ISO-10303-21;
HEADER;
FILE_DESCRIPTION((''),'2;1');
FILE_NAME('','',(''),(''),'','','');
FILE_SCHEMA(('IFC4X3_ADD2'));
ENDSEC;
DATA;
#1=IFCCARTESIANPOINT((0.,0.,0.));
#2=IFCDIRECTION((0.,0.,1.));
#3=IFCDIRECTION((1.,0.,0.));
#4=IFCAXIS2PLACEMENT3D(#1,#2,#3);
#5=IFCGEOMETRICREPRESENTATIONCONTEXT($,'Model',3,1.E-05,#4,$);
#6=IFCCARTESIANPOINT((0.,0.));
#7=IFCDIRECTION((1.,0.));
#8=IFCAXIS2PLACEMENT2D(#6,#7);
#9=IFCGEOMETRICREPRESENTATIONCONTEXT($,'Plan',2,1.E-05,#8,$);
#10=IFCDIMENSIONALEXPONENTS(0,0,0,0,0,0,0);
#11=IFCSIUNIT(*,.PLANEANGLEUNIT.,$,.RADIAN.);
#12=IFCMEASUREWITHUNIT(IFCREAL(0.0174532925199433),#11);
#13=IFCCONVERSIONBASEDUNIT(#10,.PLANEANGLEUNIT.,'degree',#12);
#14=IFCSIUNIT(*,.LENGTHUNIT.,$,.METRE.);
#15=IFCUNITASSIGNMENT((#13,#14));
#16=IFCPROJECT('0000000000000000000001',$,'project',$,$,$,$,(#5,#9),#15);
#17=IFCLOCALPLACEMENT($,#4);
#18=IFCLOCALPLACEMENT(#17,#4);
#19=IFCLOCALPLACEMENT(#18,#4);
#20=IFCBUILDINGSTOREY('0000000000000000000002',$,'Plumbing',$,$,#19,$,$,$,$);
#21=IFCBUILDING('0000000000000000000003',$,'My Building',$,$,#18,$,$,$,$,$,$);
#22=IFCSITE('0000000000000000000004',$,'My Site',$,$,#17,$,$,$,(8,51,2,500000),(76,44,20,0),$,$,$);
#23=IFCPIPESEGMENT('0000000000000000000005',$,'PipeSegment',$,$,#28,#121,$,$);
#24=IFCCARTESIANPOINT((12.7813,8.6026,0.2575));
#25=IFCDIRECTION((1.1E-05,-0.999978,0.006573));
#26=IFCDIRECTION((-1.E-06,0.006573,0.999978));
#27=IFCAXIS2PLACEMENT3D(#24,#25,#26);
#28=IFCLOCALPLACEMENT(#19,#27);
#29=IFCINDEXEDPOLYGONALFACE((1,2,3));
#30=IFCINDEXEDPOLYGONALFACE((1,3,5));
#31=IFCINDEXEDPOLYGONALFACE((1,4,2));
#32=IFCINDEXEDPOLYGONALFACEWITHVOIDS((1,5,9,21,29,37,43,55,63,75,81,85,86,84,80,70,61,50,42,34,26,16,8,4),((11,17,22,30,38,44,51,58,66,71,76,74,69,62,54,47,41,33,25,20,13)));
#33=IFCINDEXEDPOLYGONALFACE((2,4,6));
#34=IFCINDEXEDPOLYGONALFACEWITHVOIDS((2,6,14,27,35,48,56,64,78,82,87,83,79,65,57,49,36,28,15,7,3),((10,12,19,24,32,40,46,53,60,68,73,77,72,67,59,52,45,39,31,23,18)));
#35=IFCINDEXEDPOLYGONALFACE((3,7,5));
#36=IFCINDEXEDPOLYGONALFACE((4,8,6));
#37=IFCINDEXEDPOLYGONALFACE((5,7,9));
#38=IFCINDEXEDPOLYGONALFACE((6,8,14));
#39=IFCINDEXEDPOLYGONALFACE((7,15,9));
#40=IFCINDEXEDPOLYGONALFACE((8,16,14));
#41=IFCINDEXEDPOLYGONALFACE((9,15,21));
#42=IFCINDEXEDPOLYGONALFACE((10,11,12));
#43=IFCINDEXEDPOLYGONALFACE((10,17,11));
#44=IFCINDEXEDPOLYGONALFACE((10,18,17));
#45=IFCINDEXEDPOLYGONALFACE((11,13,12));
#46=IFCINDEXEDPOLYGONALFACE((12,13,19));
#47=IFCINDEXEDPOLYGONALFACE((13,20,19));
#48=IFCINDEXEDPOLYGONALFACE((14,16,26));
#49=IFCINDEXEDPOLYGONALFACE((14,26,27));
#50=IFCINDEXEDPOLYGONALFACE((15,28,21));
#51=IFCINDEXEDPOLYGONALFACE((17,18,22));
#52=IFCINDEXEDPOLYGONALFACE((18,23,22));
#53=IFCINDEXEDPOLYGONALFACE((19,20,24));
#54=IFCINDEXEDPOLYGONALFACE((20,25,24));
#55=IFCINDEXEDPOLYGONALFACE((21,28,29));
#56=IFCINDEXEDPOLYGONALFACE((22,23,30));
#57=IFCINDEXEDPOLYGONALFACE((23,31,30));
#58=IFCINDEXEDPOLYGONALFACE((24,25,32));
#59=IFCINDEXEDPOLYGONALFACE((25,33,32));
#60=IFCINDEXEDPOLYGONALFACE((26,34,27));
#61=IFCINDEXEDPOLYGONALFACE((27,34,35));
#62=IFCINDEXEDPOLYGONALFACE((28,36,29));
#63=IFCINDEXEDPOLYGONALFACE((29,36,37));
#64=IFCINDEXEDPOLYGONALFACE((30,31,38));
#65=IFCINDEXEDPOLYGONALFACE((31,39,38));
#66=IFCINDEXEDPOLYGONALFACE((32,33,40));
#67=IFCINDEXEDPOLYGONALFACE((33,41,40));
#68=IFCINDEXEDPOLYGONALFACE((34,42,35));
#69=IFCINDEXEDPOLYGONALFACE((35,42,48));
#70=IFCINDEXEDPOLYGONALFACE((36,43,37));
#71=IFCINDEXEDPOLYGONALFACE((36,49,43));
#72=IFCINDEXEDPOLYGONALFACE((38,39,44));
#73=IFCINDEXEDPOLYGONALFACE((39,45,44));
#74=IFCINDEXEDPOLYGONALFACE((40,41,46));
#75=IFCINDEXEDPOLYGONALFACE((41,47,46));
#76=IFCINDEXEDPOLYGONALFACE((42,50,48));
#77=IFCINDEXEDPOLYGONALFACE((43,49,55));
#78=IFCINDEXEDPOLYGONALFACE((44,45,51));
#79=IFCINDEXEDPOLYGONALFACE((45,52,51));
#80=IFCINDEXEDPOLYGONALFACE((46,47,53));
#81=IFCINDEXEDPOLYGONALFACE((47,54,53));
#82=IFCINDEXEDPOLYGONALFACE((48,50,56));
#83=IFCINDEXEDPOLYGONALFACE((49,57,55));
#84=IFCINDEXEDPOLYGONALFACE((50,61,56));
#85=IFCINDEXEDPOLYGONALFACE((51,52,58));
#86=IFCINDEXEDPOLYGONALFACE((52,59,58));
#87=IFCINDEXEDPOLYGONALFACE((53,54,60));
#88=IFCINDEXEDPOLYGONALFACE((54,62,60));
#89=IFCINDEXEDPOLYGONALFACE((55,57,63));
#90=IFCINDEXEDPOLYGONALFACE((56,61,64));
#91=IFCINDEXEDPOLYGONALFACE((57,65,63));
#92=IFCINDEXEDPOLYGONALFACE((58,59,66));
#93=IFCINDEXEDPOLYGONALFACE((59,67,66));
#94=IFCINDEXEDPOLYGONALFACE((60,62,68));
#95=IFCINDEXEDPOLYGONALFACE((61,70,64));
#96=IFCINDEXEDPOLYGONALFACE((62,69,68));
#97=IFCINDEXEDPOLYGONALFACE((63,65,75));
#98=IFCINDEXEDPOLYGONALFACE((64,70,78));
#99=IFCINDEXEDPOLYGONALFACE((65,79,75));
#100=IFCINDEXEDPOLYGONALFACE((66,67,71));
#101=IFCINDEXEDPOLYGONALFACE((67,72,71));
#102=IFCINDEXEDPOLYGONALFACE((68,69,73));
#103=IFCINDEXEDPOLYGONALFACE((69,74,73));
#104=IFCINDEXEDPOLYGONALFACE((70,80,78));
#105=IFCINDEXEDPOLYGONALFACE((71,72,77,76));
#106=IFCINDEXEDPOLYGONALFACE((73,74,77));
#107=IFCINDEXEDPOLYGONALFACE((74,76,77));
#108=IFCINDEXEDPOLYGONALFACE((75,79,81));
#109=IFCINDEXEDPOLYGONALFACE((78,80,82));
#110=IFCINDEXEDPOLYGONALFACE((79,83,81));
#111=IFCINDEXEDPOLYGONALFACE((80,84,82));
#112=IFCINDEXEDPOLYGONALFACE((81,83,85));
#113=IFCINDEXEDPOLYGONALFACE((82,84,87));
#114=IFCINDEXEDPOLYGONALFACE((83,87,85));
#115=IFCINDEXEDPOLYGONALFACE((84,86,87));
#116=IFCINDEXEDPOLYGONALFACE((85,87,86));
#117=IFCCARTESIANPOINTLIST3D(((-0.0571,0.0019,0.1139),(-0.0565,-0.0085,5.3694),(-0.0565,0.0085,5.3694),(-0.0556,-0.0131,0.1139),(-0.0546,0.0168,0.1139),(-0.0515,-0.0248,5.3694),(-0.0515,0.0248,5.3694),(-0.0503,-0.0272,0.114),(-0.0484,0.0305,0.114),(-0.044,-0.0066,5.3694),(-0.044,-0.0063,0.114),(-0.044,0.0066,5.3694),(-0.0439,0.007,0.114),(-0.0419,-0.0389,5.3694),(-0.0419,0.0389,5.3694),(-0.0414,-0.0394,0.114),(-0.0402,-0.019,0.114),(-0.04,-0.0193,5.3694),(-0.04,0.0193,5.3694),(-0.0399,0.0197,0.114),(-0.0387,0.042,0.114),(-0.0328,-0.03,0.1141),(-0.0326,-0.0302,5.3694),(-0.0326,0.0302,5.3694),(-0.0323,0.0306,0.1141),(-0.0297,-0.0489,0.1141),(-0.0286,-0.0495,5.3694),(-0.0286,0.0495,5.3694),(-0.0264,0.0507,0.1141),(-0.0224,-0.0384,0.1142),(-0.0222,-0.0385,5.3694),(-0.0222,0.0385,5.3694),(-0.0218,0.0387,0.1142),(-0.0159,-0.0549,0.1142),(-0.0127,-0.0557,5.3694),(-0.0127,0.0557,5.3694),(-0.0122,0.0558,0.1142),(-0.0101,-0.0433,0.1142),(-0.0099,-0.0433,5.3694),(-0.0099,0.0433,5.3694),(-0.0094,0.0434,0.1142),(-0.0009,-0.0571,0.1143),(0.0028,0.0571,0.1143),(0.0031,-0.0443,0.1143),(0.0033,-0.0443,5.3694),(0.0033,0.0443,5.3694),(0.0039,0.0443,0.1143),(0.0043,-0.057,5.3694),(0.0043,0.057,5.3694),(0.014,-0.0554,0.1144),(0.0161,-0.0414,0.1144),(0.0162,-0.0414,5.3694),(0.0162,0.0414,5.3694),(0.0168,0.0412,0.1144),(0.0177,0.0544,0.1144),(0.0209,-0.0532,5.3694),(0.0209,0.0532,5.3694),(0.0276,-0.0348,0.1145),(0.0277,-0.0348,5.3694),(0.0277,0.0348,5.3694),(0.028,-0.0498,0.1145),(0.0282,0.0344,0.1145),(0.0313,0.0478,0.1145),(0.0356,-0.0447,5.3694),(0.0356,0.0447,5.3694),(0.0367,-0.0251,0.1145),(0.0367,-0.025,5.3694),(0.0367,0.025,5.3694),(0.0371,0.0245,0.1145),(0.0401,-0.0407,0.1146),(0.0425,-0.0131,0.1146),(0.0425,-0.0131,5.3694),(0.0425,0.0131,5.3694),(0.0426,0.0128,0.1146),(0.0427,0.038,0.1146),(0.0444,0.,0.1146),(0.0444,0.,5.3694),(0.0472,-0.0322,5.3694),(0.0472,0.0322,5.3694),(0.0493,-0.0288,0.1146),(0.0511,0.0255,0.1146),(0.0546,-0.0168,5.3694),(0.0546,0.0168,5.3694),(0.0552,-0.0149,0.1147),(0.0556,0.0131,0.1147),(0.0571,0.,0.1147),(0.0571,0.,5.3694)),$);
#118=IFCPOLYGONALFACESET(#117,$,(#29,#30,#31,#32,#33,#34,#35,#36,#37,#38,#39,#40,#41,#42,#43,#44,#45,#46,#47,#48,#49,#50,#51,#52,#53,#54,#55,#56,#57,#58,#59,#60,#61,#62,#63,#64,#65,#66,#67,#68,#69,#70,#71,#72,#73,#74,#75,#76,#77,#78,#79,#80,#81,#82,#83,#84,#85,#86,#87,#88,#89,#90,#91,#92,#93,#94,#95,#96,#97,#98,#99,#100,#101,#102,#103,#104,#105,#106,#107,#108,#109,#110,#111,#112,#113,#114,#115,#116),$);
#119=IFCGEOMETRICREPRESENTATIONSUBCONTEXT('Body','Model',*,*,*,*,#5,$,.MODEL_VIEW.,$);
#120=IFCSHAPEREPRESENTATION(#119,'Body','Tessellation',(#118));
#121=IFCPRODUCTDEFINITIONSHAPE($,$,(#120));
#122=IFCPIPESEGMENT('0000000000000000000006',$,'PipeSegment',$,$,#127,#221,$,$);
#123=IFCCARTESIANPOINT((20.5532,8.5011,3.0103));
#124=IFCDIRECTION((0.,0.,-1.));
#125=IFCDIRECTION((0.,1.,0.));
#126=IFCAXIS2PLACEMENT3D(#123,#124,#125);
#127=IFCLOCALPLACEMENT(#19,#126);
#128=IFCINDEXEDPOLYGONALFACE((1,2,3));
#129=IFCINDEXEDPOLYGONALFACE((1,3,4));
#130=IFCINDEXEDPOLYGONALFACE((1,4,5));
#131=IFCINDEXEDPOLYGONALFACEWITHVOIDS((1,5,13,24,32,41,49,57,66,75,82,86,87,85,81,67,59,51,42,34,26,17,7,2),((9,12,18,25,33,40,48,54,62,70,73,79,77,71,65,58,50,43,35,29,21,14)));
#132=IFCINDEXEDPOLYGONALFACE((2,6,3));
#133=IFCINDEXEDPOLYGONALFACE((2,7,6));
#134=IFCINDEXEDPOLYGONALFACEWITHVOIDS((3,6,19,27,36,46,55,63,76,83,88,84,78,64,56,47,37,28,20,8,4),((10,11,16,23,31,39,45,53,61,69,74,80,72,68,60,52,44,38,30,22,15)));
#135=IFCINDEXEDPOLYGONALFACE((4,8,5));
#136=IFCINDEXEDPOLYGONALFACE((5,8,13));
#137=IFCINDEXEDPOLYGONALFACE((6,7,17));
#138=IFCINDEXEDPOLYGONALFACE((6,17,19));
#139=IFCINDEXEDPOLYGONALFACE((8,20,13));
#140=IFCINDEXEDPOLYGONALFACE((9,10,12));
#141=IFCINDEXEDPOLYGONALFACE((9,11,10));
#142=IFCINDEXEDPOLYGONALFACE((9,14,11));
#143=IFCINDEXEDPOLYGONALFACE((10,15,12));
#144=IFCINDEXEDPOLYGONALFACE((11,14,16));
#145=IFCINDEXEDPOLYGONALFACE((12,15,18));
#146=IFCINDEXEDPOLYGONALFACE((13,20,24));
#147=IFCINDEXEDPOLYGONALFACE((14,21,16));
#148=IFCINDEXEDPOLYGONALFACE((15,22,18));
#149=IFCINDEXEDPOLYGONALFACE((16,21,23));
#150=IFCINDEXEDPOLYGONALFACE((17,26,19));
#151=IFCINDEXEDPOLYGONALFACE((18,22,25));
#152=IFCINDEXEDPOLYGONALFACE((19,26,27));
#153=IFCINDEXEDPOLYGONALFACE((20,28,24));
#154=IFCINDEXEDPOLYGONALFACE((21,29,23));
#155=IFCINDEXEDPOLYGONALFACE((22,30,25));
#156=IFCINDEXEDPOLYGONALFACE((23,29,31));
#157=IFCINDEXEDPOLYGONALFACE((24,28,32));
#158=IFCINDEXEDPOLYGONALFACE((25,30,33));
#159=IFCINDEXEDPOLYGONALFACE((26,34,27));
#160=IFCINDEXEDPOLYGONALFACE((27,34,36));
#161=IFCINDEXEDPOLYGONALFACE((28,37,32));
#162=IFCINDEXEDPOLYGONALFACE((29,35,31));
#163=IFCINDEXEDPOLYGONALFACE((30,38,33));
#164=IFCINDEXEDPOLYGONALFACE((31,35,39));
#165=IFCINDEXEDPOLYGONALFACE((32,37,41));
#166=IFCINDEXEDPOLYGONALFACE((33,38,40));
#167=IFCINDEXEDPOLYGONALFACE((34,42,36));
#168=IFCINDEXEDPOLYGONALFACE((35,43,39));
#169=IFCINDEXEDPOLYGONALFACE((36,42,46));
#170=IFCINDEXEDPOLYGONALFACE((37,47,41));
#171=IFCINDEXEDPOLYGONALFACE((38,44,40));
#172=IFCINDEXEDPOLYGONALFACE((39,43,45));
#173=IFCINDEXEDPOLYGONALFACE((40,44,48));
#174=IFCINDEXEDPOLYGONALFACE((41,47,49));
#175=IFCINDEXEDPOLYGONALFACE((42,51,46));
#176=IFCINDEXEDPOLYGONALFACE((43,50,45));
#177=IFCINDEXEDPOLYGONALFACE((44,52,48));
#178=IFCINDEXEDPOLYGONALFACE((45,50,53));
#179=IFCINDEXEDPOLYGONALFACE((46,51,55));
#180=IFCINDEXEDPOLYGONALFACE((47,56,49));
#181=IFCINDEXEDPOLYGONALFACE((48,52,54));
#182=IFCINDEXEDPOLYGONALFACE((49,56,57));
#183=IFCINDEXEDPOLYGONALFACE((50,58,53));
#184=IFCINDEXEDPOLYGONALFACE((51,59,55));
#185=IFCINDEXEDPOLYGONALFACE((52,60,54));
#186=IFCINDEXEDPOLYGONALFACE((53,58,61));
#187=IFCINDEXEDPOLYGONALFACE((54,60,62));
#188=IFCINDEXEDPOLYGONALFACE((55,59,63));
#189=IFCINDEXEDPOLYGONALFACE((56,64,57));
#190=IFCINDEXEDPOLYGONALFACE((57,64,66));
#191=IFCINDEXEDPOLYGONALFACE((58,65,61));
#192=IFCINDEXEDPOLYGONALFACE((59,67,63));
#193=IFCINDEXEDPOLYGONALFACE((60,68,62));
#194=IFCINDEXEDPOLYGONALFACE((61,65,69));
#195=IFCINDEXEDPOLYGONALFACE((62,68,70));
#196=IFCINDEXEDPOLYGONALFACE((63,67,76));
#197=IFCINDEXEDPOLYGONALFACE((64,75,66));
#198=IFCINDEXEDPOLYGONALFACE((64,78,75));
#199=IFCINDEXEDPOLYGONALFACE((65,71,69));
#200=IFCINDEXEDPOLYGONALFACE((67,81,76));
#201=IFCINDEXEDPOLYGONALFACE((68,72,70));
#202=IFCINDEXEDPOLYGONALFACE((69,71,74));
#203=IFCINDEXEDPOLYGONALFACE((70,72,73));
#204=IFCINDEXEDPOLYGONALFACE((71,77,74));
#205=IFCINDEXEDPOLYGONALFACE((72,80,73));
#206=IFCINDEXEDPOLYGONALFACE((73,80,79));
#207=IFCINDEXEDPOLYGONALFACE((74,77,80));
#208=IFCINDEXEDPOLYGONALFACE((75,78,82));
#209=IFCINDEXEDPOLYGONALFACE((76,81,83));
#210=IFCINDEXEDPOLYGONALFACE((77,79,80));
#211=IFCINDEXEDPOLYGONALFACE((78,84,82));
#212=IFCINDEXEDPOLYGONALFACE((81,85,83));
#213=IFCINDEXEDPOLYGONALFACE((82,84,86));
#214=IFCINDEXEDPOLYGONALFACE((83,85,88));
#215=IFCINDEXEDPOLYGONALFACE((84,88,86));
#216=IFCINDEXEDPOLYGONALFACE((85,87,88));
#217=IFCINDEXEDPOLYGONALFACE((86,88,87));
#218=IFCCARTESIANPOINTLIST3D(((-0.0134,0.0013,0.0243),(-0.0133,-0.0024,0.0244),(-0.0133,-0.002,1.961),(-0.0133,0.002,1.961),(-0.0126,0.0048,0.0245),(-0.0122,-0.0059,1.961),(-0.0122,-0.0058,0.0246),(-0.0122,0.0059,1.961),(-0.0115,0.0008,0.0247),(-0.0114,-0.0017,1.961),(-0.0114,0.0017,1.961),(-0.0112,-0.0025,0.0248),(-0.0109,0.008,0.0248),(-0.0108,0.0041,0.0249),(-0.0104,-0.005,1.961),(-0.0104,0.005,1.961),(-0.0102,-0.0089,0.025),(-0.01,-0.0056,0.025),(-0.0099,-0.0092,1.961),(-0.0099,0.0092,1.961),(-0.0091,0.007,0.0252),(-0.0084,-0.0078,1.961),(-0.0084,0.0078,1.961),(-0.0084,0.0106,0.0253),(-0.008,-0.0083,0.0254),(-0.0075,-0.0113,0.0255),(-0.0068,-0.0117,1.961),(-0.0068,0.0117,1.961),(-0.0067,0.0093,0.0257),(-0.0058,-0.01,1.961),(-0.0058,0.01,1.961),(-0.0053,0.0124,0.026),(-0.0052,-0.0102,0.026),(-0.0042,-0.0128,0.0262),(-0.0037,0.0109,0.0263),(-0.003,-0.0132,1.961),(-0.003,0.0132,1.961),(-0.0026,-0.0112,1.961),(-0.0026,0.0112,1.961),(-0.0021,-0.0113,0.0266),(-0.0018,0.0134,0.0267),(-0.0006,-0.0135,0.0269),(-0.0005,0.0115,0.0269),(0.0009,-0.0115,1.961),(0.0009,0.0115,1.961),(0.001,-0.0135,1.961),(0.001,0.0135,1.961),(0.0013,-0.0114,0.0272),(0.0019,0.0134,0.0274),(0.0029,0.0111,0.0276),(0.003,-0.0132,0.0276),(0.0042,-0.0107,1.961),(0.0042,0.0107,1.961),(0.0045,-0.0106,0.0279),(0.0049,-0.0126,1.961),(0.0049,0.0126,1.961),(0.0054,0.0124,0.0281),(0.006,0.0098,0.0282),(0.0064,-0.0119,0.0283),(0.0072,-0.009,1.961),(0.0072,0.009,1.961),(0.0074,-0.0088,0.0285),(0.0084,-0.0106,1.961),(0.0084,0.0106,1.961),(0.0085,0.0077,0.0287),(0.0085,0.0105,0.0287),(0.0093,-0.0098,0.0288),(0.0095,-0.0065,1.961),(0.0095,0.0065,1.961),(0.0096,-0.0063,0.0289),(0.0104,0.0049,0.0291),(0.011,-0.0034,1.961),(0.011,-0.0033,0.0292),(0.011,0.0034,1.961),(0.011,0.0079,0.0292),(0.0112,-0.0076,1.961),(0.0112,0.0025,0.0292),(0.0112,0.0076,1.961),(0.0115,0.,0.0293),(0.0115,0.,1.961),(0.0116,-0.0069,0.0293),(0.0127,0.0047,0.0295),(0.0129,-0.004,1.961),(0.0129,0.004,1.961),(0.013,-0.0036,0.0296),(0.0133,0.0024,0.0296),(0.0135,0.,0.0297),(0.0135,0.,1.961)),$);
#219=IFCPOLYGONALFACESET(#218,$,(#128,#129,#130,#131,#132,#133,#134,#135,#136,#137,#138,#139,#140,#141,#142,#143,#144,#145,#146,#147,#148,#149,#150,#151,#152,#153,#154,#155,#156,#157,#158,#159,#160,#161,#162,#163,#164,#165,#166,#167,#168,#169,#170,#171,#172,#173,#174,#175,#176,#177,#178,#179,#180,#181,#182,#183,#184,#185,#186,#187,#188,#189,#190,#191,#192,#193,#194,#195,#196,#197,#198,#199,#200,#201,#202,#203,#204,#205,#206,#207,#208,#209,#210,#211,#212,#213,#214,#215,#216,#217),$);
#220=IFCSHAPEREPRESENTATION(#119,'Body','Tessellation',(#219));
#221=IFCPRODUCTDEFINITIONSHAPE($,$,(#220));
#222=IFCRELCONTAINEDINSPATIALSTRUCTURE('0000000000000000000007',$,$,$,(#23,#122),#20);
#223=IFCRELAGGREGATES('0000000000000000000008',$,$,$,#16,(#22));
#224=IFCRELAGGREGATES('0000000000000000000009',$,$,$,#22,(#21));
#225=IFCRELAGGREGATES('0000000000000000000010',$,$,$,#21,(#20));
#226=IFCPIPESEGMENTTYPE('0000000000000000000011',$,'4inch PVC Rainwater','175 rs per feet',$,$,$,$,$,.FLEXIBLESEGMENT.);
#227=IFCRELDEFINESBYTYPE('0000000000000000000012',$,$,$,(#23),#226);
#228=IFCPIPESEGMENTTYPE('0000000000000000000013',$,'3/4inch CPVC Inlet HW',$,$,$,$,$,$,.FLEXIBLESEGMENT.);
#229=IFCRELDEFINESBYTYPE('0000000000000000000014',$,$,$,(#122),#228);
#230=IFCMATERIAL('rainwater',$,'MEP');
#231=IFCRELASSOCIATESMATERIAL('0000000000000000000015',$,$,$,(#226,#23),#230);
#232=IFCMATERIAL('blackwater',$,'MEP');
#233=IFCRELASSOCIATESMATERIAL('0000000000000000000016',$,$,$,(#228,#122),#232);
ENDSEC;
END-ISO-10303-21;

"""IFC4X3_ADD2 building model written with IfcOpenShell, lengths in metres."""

from ifc_helpers import new_model, entity, si_unit, converted_unit, frame, origin_with_axes, origin_2d_with_axis, place, context, subcontext, project, spatial, hollow_circle, extrude, clip, halfspace, material, material_profile, profile_set, profile_usage, type_object, element, save


model = new_model("IFC4X3_ADD2")

# Units and contexts
model_context = context("Model", 3, precision=1e-05, world=origin_with_axes())
plan_context = context("Plan", 2, precision=1e-05, world=origin_2d_with_axis())
body_context = subcontext(model_context, "Body", "Model", "MODEL_VIEW")
ifc_project = project(units=[converted_unit("PLANEANGLEUNIT", "degree", entity("IfcReal", 0.0174532925199433), si_unit("PLANEANGLEUNIT", "RADIAN"), dimensions=[0, 0, 0, 0, 0, 0, 0]), si_unit("LENGTHUNIT", "METRE")], contexts=[model_context, plan_context])

# Site, building, storey
site_placement = place(None, origin_with_axes())
site = spatial("IfcSite", under=ifc_project, at=site_placement, Name="My Site", RefLatitude=(8, 51, 2, 500000), RefLongitude=(76, 44, 20, 0))
building_placement = place(site_placement, origin_with_axes())
building = spatial("IfcBuilding", under=site, at=building_placement, Name="My Building")
storey_placement = place(building_placement, origin_with_axes())
storey = spatial("IfcBuildingStorey", under=building, at=storey_placement, Name="Plumbing")

# Pipe segments
ifc_material_1 = material(Name="rainwater", Category="MEP")
ifc_material_profile_1 = material_profile(ifc_material_1, hollow_circle(Radius=0.0571, WallThickness=0.0127))
ifc_profile_set_1 = profile_set([ifc_material_profile_1], Name="rainwater")
pipe_segment_type_1 = type_object("IfcPipeSegmentType", Name="4inch PVC Rainwater", Description="175 rs per feet", PredefinedType="FLEXIBLESEGMENT", material=ifc_profile_set_1)
ifc_profile_usage_1 = profile_usage(ifc_profile_set_1)
pipe_segment_1_placement = place(storey_placement, frame((12.7813, 8.6026, 0.2575), z_axis=(0.000011, -0.999978, 0.006573), x_axis=(-0.000001, 0.006573, 0.999978)))
element("IfcPipeSegment", 1, at=pipe_segment_1_placement, inside=storey, type_object=pipe_segment_type_1, material=ifc_profile_usage_1, Name="PipeSegment", context=body_context, shape_type="Clipping", body=[
    clip(extrude(hollow_circle(Radius=0.0571, WallThickness=0.0127), origin_with_axes(), (0.0, 0.0, 1.0), 5.3694), halfspace(frame((-0.0107, 3.9893, 0.1142), z_axis=(0.006574, -0.000011, -0.999978), x_axis=(0.999978, 0.0, 0.006574)), False)),
])
ifc_material_2 = material(Name="blackwater", Category="MEP")
ifc_material_profile_2 = material_profile(ifc_material_2, hollow_circle(Radius=0.0135, WallThickness=0.002))
ifc_profile_set_2 = profile_set([ifc_material_profile_2], Name="water")
pipe_segment_type_2 = type_object("IfcPipeSegmentType", Name="3/4inch CPVC Inlet HW", PredefinedType="FLEXIBLESEGMENT", material=ifc_profile_set_2)
ifc_profile_usage_2 = profile_usage(ifc_profile_set_2)
pipe_segment_2_placement = place(storey_placement, frame((20.5532, 8.5011, 3.0103), z_axis=(0.0, 0.0, -1.0), x_axis=(0.0, 1.0, 0.0)))
element("IfcPipeSegment", 2, at=pipe_segment_2_placement, inside=storey, type_object=pipe_segment_type_2, material=ifc_profile_usage_2, Name="PipeSegment", context=body_context, shape_type="Clipping", body=[
    clip(extrude(hollow_circle(Radius=0.0135, WallThickness=0.002), origin_with_axes(), (0.0, 0.0, 1.0), 1.961), halfspace(frame((-0.0266, 0.0136, 0.0217), z_axis=(0.194654, 0.00079, -0.980871), x_axis=(0.004059, -0.999992, 0.0)), False)),
])

save(model, "model.ifc")
